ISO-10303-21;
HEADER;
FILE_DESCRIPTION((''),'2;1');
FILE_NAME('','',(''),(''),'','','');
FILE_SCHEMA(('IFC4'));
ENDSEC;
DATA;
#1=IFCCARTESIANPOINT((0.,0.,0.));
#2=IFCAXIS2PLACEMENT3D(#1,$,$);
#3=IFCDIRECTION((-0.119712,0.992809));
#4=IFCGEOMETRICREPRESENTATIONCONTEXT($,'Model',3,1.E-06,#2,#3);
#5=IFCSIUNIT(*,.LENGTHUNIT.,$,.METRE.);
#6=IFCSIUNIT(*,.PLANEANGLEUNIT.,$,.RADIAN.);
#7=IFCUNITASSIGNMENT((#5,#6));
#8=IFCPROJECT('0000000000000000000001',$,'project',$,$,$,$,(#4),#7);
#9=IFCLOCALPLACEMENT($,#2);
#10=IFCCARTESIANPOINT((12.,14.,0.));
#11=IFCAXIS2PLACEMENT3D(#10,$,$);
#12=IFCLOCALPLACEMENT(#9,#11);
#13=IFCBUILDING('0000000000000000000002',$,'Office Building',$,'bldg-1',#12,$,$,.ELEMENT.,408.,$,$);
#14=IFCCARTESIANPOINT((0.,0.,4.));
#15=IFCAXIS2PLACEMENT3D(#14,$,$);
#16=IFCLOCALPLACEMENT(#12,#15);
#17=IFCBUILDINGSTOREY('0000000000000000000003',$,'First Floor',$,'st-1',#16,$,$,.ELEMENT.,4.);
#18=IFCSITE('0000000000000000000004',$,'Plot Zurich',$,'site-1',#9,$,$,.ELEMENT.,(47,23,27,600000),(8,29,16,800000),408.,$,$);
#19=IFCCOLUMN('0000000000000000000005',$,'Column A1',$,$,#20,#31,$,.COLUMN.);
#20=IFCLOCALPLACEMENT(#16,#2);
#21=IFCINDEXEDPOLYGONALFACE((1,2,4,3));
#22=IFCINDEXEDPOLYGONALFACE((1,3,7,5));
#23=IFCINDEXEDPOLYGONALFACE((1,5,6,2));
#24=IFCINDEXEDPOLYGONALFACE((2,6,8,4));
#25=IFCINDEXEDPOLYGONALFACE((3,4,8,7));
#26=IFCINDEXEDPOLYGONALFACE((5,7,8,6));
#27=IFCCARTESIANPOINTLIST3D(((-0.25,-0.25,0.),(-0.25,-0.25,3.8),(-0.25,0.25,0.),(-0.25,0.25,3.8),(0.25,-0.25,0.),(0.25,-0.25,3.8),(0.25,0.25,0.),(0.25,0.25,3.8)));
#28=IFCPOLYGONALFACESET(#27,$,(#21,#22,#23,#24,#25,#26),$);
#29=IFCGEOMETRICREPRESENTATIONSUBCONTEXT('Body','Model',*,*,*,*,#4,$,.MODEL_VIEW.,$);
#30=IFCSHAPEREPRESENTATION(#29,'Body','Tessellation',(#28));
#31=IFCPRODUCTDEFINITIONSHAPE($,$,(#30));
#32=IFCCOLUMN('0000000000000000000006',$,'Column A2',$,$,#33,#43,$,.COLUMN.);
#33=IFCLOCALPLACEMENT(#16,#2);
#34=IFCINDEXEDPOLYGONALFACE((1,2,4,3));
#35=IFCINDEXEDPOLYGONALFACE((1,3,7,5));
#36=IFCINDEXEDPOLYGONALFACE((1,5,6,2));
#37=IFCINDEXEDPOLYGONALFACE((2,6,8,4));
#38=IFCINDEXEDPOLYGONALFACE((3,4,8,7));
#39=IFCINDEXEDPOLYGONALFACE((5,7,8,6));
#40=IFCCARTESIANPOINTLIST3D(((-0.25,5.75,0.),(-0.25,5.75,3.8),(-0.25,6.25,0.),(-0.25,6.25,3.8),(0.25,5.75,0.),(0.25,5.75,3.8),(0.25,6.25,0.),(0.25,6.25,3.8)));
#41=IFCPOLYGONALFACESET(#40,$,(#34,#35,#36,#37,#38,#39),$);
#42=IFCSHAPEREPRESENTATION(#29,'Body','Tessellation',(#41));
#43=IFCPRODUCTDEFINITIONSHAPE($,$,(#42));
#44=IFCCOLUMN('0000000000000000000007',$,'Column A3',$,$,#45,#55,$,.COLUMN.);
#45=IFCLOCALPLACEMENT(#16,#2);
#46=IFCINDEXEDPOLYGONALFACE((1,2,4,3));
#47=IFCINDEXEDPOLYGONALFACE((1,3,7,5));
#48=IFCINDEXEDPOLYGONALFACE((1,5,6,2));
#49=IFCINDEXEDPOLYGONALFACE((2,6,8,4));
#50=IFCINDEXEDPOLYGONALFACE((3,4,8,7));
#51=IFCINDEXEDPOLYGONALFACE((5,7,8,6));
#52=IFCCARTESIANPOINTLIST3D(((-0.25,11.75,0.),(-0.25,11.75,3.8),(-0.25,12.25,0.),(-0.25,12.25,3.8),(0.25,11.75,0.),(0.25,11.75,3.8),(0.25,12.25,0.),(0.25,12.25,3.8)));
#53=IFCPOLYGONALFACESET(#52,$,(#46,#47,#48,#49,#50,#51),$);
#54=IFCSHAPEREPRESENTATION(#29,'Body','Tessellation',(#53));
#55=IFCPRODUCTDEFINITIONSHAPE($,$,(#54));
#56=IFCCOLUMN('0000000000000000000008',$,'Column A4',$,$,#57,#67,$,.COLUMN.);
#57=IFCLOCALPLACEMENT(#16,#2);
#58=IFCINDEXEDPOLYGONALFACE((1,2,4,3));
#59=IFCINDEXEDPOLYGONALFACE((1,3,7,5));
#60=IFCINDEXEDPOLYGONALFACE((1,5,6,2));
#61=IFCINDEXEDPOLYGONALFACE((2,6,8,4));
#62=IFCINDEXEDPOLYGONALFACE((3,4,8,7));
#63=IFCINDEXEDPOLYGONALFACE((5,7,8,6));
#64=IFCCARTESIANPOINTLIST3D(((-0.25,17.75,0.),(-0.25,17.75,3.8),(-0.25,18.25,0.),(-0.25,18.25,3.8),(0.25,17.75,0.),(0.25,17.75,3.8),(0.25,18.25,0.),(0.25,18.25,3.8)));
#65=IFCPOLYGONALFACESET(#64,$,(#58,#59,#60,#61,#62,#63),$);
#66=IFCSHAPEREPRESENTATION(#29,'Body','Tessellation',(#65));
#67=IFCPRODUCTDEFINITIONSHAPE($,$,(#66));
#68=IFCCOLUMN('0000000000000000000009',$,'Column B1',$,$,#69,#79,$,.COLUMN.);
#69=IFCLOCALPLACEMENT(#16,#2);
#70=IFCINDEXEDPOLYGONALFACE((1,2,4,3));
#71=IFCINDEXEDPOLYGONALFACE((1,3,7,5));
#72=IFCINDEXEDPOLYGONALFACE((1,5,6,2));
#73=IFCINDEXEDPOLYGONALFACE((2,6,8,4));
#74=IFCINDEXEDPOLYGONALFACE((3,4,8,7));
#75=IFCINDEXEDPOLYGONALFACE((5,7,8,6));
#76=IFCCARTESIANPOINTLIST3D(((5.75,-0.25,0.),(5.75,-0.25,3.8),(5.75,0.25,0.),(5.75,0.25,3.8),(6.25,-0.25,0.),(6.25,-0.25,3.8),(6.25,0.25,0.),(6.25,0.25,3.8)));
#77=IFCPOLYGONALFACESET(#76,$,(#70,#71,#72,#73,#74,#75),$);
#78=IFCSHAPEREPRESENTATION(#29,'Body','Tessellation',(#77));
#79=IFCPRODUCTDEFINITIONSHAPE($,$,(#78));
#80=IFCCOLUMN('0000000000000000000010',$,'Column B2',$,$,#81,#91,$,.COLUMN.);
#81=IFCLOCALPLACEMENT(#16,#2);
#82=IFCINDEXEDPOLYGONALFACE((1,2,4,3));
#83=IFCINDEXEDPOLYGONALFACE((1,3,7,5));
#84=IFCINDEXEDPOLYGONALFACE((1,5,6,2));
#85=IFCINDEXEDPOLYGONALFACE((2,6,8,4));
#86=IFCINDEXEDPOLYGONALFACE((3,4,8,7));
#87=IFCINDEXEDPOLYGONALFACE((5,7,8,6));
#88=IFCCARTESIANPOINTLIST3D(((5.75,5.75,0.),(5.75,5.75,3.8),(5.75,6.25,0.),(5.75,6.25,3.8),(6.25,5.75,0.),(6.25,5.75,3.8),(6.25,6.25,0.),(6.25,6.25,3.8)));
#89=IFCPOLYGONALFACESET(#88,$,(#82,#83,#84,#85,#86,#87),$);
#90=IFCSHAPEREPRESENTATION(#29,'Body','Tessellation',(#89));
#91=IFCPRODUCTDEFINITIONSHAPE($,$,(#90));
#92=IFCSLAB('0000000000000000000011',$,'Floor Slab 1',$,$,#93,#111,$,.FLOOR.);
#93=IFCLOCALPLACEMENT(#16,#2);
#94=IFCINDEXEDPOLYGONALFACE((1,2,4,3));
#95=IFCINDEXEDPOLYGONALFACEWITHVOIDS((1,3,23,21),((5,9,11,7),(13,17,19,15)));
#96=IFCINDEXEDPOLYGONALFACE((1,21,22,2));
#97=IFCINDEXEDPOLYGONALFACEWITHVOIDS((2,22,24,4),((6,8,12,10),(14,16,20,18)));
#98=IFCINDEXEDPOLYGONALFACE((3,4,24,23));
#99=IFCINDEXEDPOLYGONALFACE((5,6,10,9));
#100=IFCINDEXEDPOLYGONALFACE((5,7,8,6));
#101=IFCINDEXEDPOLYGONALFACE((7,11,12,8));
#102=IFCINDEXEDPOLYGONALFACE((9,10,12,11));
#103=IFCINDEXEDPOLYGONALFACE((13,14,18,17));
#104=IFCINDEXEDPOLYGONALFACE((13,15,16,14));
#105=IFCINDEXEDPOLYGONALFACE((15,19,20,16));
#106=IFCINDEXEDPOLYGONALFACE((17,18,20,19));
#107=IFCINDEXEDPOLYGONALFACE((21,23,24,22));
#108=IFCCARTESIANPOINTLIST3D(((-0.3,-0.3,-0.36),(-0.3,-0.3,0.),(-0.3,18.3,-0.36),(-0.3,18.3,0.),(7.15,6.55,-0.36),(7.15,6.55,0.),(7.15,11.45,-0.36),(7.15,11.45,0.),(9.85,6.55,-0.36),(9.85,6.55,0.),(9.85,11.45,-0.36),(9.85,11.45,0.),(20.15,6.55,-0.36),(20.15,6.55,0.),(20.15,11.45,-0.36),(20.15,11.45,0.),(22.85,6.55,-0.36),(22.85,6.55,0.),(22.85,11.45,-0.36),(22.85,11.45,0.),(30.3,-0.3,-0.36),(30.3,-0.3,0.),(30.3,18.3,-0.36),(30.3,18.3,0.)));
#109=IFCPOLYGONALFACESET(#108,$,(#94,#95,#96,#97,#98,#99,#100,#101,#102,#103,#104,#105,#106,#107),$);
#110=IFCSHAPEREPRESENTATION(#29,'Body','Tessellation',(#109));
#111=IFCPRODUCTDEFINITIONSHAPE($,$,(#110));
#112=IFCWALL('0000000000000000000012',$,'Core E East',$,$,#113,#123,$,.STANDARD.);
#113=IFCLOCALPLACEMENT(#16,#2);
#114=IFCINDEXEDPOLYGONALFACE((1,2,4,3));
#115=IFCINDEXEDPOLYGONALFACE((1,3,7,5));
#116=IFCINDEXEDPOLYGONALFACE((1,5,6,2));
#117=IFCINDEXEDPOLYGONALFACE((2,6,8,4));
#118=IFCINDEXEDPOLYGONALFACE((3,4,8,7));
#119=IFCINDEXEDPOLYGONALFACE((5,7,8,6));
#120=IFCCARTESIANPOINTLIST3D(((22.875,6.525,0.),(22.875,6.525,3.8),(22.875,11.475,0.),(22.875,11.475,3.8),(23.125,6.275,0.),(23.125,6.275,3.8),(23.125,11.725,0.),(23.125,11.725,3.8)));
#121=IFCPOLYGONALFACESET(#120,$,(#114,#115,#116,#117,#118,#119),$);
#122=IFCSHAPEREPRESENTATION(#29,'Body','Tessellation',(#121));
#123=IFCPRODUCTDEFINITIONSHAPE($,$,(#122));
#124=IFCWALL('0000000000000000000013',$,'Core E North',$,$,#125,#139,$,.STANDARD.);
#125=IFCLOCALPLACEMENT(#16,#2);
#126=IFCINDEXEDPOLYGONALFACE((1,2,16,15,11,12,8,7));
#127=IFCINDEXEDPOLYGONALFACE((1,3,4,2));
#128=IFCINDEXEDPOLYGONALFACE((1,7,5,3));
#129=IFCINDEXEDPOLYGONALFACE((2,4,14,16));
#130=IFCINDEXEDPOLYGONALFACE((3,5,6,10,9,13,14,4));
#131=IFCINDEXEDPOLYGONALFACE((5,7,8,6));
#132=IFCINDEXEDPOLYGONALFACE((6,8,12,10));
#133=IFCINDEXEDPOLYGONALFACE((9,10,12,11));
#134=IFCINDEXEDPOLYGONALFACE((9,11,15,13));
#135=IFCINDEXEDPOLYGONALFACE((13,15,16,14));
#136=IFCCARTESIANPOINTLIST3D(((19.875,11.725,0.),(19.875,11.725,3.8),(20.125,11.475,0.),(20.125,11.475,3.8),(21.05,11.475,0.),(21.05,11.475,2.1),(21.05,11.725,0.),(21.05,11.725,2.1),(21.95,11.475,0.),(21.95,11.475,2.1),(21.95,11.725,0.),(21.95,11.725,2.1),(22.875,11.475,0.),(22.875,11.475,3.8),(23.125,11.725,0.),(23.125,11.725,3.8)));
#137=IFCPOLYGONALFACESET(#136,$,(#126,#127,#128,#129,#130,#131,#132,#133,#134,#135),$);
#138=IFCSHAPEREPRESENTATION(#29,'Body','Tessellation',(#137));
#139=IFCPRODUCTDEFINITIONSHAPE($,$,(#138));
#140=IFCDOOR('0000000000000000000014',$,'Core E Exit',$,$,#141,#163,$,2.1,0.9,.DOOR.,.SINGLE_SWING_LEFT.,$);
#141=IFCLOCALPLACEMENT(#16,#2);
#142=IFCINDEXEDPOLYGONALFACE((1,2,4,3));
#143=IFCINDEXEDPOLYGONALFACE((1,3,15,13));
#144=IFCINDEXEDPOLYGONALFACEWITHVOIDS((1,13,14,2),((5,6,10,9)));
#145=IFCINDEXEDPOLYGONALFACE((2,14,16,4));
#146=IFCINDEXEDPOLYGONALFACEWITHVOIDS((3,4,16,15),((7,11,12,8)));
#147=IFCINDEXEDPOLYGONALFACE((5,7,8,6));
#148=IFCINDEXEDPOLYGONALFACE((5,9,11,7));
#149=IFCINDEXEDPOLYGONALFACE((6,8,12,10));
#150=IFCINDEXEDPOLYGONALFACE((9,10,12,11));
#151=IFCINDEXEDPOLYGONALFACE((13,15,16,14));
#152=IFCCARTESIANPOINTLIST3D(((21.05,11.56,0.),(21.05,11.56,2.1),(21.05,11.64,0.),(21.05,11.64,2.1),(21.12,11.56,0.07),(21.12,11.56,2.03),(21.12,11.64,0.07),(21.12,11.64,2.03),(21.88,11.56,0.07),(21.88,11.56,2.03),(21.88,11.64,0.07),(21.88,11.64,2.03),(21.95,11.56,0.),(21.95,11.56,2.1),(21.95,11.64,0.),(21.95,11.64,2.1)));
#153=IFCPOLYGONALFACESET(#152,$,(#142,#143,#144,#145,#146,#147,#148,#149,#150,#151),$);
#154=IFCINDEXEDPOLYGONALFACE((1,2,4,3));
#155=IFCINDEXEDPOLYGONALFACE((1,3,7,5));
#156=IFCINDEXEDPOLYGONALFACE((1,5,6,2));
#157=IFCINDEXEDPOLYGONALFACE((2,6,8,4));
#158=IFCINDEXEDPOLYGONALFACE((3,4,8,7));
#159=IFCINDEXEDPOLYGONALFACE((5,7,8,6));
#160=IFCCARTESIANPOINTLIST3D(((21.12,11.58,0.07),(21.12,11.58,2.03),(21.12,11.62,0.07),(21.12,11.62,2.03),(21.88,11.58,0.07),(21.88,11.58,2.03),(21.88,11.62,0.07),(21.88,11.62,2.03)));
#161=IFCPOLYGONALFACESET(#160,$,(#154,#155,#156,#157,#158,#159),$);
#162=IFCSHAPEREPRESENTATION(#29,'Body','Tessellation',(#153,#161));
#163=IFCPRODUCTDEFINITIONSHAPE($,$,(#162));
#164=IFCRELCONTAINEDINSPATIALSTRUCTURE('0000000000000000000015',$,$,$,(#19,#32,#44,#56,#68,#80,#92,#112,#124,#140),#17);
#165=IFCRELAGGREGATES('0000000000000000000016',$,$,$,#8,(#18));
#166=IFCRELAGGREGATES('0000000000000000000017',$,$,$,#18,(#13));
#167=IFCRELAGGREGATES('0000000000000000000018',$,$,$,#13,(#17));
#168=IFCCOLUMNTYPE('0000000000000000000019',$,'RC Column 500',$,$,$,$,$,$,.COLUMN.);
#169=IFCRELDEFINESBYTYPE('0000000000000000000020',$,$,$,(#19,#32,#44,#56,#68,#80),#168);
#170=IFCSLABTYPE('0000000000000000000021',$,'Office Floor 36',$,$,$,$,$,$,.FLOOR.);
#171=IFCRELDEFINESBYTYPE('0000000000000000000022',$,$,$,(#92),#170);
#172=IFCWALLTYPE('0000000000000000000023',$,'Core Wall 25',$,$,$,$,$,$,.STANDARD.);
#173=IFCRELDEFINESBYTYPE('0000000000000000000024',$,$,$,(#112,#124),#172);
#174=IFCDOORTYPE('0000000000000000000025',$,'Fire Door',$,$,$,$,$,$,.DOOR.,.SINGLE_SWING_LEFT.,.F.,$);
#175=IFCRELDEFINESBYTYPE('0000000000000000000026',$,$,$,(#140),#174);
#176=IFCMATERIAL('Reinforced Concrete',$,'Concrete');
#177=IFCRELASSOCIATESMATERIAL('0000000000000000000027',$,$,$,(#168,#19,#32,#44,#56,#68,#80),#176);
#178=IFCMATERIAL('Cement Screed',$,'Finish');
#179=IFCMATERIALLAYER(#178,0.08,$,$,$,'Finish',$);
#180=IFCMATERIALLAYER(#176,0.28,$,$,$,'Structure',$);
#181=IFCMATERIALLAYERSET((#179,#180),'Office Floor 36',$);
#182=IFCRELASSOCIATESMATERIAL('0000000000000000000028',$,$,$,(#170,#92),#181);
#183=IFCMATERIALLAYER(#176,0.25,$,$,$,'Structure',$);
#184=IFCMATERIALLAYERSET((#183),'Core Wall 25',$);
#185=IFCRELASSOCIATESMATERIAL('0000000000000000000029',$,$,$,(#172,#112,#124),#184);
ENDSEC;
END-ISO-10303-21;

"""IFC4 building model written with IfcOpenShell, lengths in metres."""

from ifc_helpers import new_model, si_unit, direction, frame, frame_2d, origin, origin_2d, place, context, subcontext, project, spatial, polyline, rectangle, outline, extrude, material, layer, layer_set, layer_usage, type_object, element, fill, save


model = new_model("IFC4")

# Units and contexts
model_context = context("Model", 3, precision=1e-06, world=origin(), true_north=direction((-0.119712, 0.992809)))
body_context = subcontext(model_context, "Body", "Model", "MODEL_VIEW")
ifc_project = project(units=[si_unit("LENGTHUNIT", "METRE"), si_unit("PLANEANGLEUNIT", "RADIAN")], contexts=[model_context])

# Site, building, storey
site_placement = place(None, origin())
site = spatial("IfcSite", under=ifc_project, at=site_placement, Name="Plot Zurich", ObjectType="site-1", CompositionType="ELEMENT", RefLatitude=(47, 23, 27, 600000), RefLongitude=(8, 29, 16, 800000), RefElevation=408.0)
building_placement = place(site_placement, frame((12.0, 14.0, 0.0)))
building = spatial("IfcBuilding", under=site, at=building_placement, Name="Office Building", ObjectType="bldg-1", CompositionType="ELEMENT", ElevationOfRefHeight=408.0)
storey_placement = place(building_placement, frame((0.0, 0.0, 4.0)))
storey = spatial("IfcBuildingStorey", under=building, at=storey_placement, Name="First Floor", ObjectType="st-1", CompositionType="ELEMENT", Elevation=4.0)

# Columns
ifc_material_1 = material(Name="Reinforced Concrete", Category="Concrete")
column_type = type_object("IfcColumnType", Name="RC Column 500", PredefinedType="COLUMN", material=ifc_material_1)
for number, where, name in (
    (1, (0.0, 0.0, 0.0), "Column A1"),
    (2, (0.0, 6.0, 0.0), "Column A2"),
    (3, (0.0, 12.0, 0.0), "Column A3"),
    (4, (0.0, 18.0, 0.0), "Column A4"),
    (5, (6.0, 0.0, 0.0), "Column B1"),
    (6, (6.0, 6.0, 0.0), "Column B2"),
):
    element("IfcColumn", number, at=place(storey_placement, frame(where)), inside=storey, type_object=column_type, material=ifc_material_1, Name=name, PredefinedType="COLUMN", context=body_context, shape_type="SweptSolid", body=[
        extrude(rectangle(XDim=0.5, YDim=0.5, at=origin_2d()), origin(), (0.0, 0.0, 1.0), 3.8),
    ])

# Slab
ifc_material_2 = material(Name="Cement Screed", Category="Finish")
ifc_layer_1 = layer(ifc_material_2, 0.08, Category="Finish")
ifc_layer_2 = layer(ifc_material_1, 0.28, Category="Structure")
ifc_layer_set_1 = layer_set([ifc_layer_1, ifc_layer_2], Name="Office Floor 36")
ifc_layer_usage_1 = layer_usage(ifc_layer_set_1, "AXIS3", "NEGATIVE", 0.36)
slab_type = type_object("IfcSlabType", Name="Office Floor 36", PredefinedType="FLOOR", material=ifc_layer_set_1)
slab_placement = place(storey_placement, frame((0.0, 0.0, -0.36)))
element("IfcSlab", 7, at=slab_placement, inside=storey, type_object=slab_type, material=ifc_layer_usage_1, Name="Floor Slab 1", PredefinedType="FLOOR", context=body_context, shape_type="SweptSolid", body=[
    extrude(outline(polyline([(-0.3, -0.3), (30.3, -0.3), (30.3, 18.3), (-0.3, 18.3), (-0.3, -0.3)]), holes=[polyline([(7.15, 6.55), (7.15, 11.45), (9.85, 11.45), (9.85, 6.55), (7.15, 6.55)]), polyline([(20.15, 6.55), (20.15, 11.45), (22.85, 11.45), (22.85, 6.55), (20.15, 6.55)])]), origin(), (0.0, 0.0, 1.0), 0.36),
])

# Wall
ifc_layer_3 = layer(ifc_material_1, 0.25, Category="Structure")
ifc_layer_set_2 = layer_set([ifc_layer_3], Name="Core Wall 25")
ifc_layer_usage_2 = layer_usage(ifc_layer_set_2, "AXIS2", "NEGATIVE", 0.125)
wall_type_1 = type_object("IfcWallType", Name="Core Wall 25", PredefinedType="STANDARD", material=ifc_layer_set_2)
wall_1_placement = place(storey_placement, origin())
element("IfcWall", 8, at=wall_1_placement, inside=storey, type_object=wall_type_1, material=ifc_layer_usage_2, Name="Core E East", PredefinedType="STANDARD", context=body_context, shape_type="SweptSolid", body=[
    extrude(outline(polyline([(23.125, 6.275), (23.125, 11.725), (22.875, 11.475), (22.875, 6.525), (23.125, 6.275)])), origin(), (0.0, 0.0, 1.0), 3.8),
])

# Wall, opening, door
ifc_layer_usage_3 = layer_usage(ifc_layer_set_2, "AXIS2", "NEGATIVE", 0.125)
wall_2_placement = place(storey_placement, origin())
wall_2 = element("IfcWall", 9, at=wall_2_placement, inside=storey, type_object=wall_type_1, material=ifc_layer_usage_3, Name="Core E North", PredefinedType="STANDARD", context=body_context, shape_type="SweptSolid", body=[
    extrude(outline(polyline([(23.125, 11.725), (19.875, 11.725), (20.125, 11.475), (22.875, 11.475), (23.125, 11.725)])), origin(), (0.0, 0.0, 1.0), 3.8),
])
opening_1_placement = place(wall_2_placement, frame((21.5, 11.6, 0.0), z_axis=(0.0, 0.0, 1.0), x_axis=(-1.0, 0.0, 0.0)))
opening_1 = element("IfcOpeningElement", 10, at=opening_1_placement, cuts=wall_2, PredefinedType="OPENING", context=body_context, shape_type="SweptSolid", body=[
    extrude(rectangle(XDim=0.9, YDim=0.25, at=origin_2d()), origin(), (0.0, 0.0, 1.0), 2.1),
])
door_type = type_object("IfcDoorType", Name="Fire Door", OperationType="SINGLE_SWING_LEFT", ParameterTakesPrecedence=False, PredefinedType="DOOR")
door_1_placement = place(opening_1_placement, frame((0.0, 0.0, 0.0), z_axis=(0.0, -1.0, 0.0), x_axis=(1.0, 0.0, 0.0)))
door_1 = element("IfcDoor", 11, at=door_1_placement, inside=storey, type_object=door_type, Name="Core E Exit", OperationType="SINGLE_SWING_LEFT", OverallHeight=2.1, OverallWidth=0.9, PredefinedType="DOOR", context=body_context, shape_type="SweptSolid", body=[
    extrude(outline(polyline([(-0.45, 0.0), (0.45, 0.0), (0.45, 2.1), (-0.45, 2.1), (-0.45, 0.0)]), holes=[polyline([(-0.38, 0.07), (0.38, 0.07), (0.38, 2.03), (-0.38, 2.03), (-0.38, 0.07)])]), frame((0.0, 0.0, -0.04)), (0.0, 0.0, 1.0), 0.08),
    extrude(rectangle(XDim=0.76, YDim=1.96, at=frame_2d((0.0, 1.05))), frame((0.0, 0.0, -0.02)), (0.0, 0.0, 1.0), 0.04),
])
fill(opening_1, door_1)

save(model, "model.ifc")
